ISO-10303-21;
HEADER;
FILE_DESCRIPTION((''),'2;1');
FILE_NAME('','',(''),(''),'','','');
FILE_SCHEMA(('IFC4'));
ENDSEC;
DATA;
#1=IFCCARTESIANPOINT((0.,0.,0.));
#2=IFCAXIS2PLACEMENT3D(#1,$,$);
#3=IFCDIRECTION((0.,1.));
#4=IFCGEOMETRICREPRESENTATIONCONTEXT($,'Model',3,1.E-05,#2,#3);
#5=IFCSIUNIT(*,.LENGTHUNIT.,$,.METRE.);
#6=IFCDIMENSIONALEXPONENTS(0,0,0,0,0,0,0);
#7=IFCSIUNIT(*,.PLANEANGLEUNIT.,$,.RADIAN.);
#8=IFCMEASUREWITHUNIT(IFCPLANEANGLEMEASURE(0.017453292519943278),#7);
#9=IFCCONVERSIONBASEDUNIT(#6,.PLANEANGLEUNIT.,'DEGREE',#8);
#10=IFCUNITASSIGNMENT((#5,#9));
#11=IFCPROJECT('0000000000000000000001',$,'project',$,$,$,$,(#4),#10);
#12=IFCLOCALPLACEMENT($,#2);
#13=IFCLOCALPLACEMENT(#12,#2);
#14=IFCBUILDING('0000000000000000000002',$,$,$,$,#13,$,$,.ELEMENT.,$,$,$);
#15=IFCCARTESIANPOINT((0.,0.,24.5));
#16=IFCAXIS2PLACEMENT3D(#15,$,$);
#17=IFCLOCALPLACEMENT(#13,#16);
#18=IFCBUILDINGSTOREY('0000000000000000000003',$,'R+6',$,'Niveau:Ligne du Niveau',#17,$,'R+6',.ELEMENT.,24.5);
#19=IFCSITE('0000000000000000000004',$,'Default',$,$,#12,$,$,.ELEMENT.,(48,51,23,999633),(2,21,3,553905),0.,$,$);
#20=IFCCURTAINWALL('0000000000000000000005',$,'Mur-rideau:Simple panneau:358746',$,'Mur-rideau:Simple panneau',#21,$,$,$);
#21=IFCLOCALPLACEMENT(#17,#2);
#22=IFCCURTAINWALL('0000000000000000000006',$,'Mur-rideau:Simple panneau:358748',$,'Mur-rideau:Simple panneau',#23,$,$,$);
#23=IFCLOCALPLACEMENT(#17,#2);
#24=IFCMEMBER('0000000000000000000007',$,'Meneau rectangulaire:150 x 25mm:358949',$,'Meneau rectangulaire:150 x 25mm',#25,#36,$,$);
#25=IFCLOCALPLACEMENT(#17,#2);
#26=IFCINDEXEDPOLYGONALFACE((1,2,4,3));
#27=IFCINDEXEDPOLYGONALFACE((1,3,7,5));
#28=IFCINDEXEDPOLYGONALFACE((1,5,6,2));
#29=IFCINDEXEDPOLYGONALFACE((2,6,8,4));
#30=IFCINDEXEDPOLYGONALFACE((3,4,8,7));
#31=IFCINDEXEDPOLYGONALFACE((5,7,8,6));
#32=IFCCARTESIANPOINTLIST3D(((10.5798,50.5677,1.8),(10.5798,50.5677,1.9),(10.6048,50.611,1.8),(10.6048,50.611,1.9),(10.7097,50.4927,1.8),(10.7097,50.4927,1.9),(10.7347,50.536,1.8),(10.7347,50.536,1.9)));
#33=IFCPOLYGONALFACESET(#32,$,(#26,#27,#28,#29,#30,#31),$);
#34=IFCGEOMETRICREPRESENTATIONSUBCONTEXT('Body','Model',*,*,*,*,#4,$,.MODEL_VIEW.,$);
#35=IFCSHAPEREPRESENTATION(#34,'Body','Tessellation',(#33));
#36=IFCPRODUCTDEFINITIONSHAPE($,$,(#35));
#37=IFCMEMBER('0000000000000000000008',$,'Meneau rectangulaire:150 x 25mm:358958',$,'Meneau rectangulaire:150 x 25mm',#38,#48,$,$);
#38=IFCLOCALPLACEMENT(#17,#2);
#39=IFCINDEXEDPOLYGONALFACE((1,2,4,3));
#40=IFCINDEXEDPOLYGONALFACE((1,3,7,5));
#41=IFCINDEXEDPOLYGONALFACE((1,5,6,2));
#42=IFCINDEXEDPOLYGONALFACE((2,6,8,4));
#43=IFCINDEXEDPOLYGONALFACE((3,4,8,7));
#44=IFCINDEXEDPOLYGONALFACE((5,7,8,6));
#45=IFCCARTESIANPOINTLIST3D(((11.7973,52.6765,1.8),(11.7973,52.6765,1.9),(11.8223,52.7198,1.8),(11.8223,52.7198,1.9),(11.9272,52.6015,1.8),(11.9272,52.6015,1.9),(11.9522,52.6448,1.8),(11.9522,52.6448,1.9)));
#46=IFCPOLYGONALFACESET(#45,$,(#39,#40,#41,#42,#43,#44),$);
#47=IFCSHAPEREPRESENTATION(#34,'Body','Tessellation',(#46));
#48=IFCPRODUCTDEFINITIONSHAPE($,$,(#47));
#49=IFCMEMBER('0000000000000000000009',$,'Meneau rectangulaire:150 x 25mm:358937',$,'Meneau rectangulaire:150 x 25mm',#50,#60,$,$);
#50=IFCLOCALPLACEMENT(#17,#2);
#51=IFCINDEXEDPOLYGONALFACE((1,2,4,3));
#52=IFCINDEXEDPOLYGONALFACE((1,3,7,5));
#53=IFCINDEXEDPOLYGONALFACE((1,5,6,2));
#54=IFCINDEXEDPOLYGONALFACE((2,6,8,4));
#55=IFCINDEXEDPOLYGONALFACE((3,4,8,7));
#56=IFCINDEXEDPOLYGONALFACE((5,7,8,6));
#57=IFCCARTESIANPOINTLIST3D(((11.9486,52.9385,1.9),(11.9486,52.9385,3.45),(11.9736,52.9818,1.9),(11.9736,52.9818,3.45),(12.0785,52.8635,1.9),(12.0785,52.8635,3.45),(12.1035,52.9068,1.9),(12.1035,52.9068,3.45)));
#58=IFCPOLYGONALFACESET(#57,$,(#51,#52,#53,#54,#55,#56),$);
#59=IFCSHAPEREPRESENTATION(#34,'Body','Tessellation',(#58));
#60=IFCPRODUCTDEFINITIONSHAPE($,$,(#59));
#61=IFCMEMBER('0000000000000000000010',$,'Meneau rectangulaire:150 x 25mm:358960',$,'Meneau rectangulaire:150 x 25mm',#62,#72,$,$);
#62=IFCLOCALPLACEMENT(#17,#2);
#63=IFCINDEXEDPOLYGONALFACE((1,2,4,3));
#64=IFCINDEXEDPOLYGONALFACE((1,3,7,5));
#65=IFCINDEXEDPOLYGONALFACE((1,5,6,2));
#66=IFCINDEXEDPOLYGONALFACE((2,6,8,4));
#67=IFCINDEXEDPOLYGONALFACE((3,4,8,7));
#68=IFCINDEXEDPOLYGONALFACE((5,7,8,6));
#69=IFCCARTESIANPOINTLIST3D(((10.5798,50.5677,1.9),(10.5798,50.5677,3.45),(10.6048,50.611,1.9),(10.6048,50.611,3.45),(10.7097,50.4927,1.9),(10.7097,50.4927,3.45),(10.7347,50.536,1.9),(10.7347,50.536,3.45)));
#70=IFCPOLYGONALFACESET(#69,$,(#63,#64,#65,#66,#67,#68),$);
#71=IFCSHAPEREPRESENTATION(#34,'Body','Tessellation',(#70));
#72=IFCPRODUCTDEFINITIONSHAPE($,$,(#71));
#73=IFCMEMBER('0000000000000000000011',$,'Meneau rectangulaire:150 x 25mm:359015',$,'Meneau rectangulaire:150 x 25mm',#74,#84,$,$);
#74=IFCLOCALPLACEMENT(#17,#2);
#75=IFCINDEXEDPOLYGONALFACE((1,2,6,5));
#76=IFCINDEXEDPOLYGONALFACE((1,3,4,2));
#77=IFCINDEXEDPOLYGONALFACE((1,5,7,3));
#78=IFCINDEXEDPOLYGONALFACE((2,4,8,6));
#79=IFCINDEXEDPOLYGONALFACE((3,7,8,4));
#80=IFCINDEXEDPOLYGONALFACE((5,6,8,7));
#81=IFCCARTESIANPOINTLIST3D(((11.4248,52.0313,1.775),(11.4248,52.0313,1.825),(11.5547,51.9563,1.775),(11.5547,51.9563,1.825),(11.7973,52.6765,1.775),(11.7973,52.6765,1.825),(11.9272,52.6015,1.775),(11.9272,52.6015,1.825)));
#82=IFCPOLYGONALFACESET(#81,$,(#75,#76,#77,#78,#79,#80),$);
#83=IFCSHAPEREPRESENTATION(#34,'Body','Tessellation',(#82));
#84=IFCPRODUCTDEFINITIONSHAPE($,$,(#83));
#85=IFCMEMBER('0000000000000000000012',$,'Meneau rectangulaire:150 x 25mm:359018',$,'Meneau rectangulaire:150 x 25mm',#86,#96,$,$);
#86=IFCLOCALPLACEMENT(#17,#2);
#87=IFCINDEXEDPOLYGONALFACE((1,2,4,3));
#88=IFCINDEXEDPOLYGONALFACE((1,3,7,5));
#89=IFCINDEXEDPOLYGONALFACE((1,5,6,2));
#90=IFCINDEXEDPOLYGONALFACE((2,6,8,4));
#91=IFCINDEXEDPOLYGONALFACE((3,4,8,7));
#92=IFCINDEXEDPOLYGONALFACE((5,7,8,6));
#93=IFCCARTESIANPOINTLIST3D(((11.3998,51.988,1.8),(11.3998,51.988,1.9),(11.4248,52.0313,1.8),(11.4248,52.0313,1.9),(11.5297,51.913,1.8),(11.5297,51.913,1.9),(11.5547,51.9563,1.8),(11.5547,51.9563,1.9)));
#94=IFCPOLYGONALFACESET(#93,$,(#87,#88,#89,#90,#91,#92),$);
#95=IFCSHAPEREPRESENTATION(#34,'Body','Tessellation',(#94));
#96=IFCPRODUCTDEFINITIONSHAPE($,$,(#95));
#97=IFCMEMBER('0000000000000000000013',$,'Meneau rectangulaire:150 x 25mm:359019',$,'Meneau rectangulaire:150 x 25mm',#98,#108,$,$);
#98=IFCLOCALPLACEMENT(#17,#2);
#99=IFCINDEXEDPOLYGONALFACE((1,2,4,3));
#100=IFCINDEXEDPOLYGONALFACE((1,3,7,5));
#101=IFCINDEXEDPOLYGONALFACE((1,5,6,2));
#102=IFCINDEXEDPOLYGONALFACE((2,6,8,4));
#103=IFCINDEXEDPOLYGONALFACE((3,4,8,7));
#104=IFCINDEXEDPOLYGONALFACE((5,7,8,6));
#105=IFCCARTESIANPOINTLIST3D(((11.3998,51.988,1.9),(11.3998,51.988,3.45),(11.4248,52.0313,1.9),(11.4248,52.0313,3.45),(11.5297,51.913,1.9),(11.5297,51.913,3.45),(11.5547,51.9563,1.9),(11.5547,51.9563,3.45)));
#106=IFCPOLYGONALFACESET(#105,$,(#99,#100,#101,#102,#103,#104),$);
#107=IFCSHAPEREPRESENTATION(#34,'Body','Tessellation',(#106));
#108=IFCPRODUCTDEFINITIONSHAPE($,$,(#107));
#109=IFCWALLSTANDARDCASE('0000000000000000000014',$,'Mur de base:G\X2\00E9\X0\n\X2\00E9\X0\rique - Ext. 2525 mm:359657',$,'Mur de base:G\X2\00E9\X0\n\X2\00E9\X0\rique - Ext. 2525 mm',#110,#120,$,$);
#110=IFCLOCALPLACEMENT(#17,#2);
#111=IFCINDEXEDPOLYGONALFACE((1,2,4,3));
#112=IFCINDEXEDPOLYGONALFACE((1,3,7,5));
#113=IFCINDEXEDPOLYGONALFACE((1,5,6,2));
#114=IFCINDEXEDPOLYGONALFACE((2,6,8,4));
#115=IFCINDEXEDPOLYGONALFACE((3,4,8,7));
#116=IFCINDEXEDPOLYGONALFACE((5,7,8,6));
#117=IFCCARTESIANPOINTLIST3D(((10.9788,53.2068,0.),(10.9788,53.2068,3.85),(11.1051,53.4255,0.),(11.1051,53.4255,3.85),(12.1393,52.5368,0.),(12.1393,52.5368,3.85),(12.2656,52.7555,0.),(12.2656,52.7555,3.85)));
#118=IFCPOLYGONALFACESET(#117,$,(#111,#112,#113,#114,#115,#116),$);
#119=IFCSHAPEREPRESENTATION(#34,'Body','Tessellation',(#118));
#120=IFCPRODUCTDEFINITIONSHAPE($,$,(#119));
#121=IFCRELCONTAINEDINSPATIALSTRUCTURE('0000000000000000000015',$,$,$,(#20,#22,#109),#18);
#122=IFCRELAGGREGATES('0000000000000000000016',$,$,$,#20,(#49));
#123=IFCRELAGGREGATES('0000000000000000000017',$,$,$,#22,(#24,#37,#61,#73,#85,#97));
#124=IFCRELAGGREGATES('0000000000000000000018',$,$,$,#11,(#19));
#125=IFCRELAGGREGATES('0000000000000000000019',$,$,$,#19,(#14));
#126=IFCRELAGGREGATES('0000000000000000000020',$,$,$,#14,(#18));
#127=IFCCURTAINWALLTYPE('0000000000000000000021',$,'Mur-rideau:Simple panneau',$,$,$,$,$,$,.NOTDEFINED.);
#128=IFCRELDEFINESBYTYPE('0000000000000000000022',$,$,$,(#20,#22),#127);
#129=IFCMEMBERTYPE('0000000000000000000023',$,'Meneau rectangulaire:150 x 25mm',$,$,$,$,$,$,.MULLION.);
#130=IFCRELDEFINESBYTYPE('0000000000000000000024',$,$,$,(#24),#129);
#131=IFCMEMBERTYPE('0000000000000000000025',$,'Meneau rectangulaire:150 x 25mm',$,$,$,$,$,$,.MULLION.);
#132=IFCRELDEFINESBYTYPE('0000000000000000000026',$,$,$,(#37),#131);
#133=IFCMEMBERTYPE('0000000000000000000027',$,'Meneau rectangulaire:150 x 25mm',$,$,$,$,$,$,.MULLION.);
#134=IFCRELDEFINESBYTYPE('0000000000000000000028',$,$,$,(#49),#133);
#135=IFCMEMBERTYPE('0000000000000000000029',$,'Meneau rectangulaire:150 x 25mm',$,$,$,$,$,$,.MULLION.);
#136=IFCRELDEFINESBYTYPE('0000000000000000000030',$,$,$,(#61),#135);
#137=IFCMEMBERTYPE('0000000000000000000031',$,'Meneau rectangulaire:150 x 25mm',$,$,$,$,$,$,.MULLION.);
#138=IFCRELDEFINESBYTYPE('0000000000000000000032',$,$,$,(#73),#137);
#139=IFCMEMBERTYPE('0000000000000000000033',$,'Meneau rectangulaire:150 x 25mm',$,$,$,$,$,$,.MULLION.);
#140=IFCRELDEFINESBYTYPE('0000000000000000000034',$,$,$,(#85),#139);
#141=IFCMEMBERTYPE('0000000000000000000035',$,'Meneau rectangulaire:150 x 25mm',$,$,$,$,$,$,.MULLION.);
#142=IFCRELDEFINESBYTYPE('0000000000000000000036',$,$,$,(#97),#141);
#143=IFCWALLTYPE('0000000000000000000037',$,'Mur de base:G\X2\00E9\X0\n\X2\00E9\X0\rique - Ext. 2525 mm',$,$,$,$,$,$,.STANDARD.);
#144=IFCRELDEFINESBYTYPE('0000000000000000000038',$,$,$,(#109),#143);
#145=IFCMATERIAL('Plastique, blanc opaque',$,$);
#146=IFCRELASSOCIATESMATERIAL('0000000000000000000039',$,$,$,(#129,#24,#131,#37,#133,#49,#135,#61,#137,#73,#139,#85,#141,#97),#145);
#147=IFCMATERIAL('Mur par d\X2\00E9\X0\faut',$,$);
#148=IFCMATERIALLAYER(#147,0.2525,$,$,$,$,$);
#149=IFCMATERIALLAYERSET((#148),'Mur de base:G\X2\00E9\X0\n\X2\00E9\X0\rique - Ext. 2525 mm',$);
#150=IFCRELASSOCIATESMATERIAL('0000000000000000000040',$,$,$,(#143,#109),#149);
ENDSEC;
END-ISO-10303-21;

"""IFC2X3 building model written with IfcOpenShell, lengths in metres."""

from ifc_helpers import new_model, entity, si_unit, converted_unit, direction, frame, frame_2d, origin, origin_2d_with_axis, place, context, subcontext, project, spatial, rectangle, extrude, source, transform, mapped, material, layer, layer_set, layer_usage, type_object, type_shapes, element, aggregate, save


model = new_model("IFC2X3")

# Units and contexts
model_context = context("Model", 3, precision=1e-05, world=origin(), true_north=direction((0.0, 1.0)))
body_context = subcontext(model_context, "Body", "Model", "MODEL_VIEW")
ifc_project = project(units=[si_unit("LENGTHUNIT", "METRE"), converted_unit("PLANEANGLEUNIT", "DEGREE", entity("IfcPlaneAngleMeasure", 0.017453292519943278), si_unit("PLANEANGLEUNIT", "RADIAN"), dimensions=[0, 0, 0, 0, 0, 0, 0])], contexts=[model_context])

# Site, building, storey
site_placement = place(None, origin())
site = spatial("IfcSite", under=ifc_project, at=site_placement, Name="Default", CompositionType="ELEMENT", RefLatitude=(48, 51, 23, 999633), RefLongitude=(2, 21, 3, 553905), RefElevation=0.0)
building_placement = place(site_placement, origin())
building = spatial("IfcBuilding", under=site, at=building_placement, CompositionType="ELEMENT")
storey_placement = place(building_placement, frame((0.0, 0.0, 24.5)))
storey = spatial("IfcBuildingStorey", under=building, at=storey_placement, Name="R+6", ObjectType="Niveau:Ligne du Niveau", LongName="R+6", CompositionType="ELEMENT", Elevation=24.5)

# Curtain wall
curtain_wall_type = type_object("IfcCurtainWallType", Name="Mur-rideau:Simple panneau", PredefinedType="NOTDEFINED")
curtain_wall_1_placement = place(storey_placement, frame((0.0, 0.0, -24.5)))
curtain_wall_1 = element("IfcCurtainWall", 1, at=curtain_wall_1_placement, inside=storey, type_object=curtain_wall_type, Name="Mur-rideau:Simple panneau:358746", ObjectType="Mur-rideau:Simple panneau")
ifc_material_1 = material(Name="Plastique, blanc opaque")

# Curtain wall
curtain_wall_2_placement = place(storey_placement, frame((0.0, 0.0, -24.5)))
curtain_wall_2 = element("IfcCurtainWall", 2, at=curtain_wall_2_placement, inside=storey, type_object=curtain_wall_type, Name="Mur-rideau:Simple panneau:358748", ObjectType="Mur-rideau:Simple panneau")

# Members
member_type_1 = type_object("IfcMemberType", Name="Meneau rectangulaire:150 x 25mm", PredefinedType="MULLION", material=ifc_material_1)
shared_shape_1 = source(origin(), body_context, "Body", "SweptSolid", [
    extrude(rectangle(XDim=0.05, YDim=0.15, at=origin_2d_with_axis()), frame((0.0, 0.0, -0.1), z_axis=(0.0, 0.0, 1.0), x_axis=(-1.0, 0.0, 0.0)), (0.0, 0.0, 1.0), 0.1),
])
type_shapes(member_type_1, [shared_shape_1])
member_1_placement = place(curtain_wall_2_placement, frame((10.6573, 50.5519, 26.3), z_axis=(0.0, 0.0, -1.0), x_axis=(-0.5, -0.866025, 0.0)))
member_1 = element("IfcMember", 3, at=member_1_placement, type_object=member_type_1, material=ifc_material_1, Name="Meneau rectangulaire:150 x 25mm:358949", ObjectType="Meneau rectangulaire:150 x 25mm", context=body_context, shape_type="MappedRepresentation", body=[
    mapped(shared_shape_1, transform((0.0, 0.0, 0.0), scale=1.0)),
])
member_type_2 = type_object("IfcMemberType", Name="Meneau rectangulaire:150 x 25mm", PredefinedType="MULLION", material=ifc_material_1)
shared_shape_2 = source(origin(), body_context, "Body", "SweptSolid", [
    extrude(rectangle(XDim=0.05, YDim=0.15, at=origin_2d_with_axis()), frame((-0.025, 0.0, -0.1), z_axis=(0.0, 0.0, 1.0), x_axis=(-1.0, 0.0, 0.0)), (0.0, 0.0, 1.0), 0.1),
])
type_shapes(member_type_2, [shared_shape_2])
member_2_placement = place(curtain_wall_2_placement, frame((11.8873, 52.6823, 26.4), z_axis=(0.0, 0.0, 1.0), x_axis=(0.5, 0.866025, 0.0)))
member_2 = element("IfcMember", 4, at=member_2_placement, type_object=member_type_2, material=ifc_material_1, Name="Meneau rectangulaire:150 x 25mm:358958", ObjectType="Meneau rectangulaire:150 x 25mm", context=body_context, shape_type="MappedRepresentation", body=[
    mapped(shared_shape_2, transform((0.0, 0.0, 0.0), scale=1.0)),
])
member_type_3 = type_object("IfcMemberType", Name="Meneau rectangulaire:150 x 25mm", PredefinedType="MULLION", material=ifc_material_1)
shared_shape_3 = source(origin(), body_context, "Body", "SweptSolid", [
    extrude(rectangle(XDim=0.05, YDim=0.15, at=origin_2d_with_axis()), frame((-0.025, 0.0, -1.55), z_axis=(0.0, 0.0, 1.0), x_axis=(-1.0, 0.0, 0.0)), (0.0, 0.0, 1.0), 1.55),
])
type_shapes(member_type_3, [shared_shape_3])
member_3_placement = place(curtain_wall_1_placement, frame((12.0135, 52.901, 26.4), z_axis=(0.0, 0.0, -1.0), x_axis=(-0.5, -0.866025, 0.0)))
member_3 = element("IfcMember", 5, at=member_3_placement, type_object=member_type_3, material=ifc_material_1, Name="Meneau rectangulaire:150 x 25mm:358937", ObjectType="Meneau rectangulaire:150 x 25mm", context=body_context, shape_type="MappedRepresentation", body=[
    mapped(shared_shape_3, transform((0.0, 0.0, 0.0), scale=1.0)),
])
member_type_4 = type_object("IfcMemberType", Name="Meneau rectangulaire:150 x 25mm", PredefinedType="MULLION", material=ifc_material_1)
shared_shape_4 = source(origin(), body_context, "Body", "SweptSolid", [
    extrude(rectangle(XDim=0.05, YDim=0.15, at=origin_2d_with_axis()), frame((0.0, 0.0, -1.55), z_axis=(0.0, 0.0, 1.0), x_axis=(-1.0, 0.0, 0.0)), (0.0, 0.0, 1.0), 1.55),
])
type_shapes(member_type_4, [shared_shape_4])
member_4_placement = place(curtain_wall_2_placement, frame((10.6573, 50.5519, 26.4), z_axis=(0.0, 0.0, -1.0), x_axis=(-0.5, -0.866025, 0.0)))
member_4 = element("IfcMember", 6, at=member_4_placement, type_object=member_type_4, material=ifc_material_1, Name="Meneau rectangulaire:150 x 25mm:358960", ObjectType="Meneau rectangulaire:150 x 25mm", context=body_context, shape_type="MappedRepresentation", body=[
    mapped(shared_shape_4, transform((0.0, 0.0, 0.0), scale=1.0)),
])
member_type_5 = type_object("IfcMemberType", Name="Meneau rectangulaire:150 x 25mm", PredefinedType="MULLION", material=ifc_material_1)
shared_shape_5 = source(origin(), body_context, "Body", "SweptSolid", [
    extrude(rectangle(XDim=0.05, YDim=0.15, at=origin_2d_with_axis()), frame((0.0, 0.0, -0.745), z_axis=(0.0, 0.0, 1.0), x_axis=(-1.0, 0.0, 0.0)), (0.0, 0.0, 1.0), 0.745),
])
type_shapes(member_type_5, [shared_shape_5])
member_5_placement = place(curtain_wall_2_placement, frame((11.4898, 51.9938, 26.3), z_axis=(-0.5, -0.866025, 0.0), x_axis=(0.0, 0.0, 1.0)))
member_5 = element("IfcMember", 7, at=member_5_placement, type_object=member_type_5, material=ifc_material_1, Name="Meneau rectangulaire:150 x 25mm:359015", ObjectType="Meneau rectangulaire:150 x 25mm", context=body_context, shape_type="MappedRepresentation", body=[
    mapped(shared_shape_5, transform((0.0, 0.0, 0.0), scale=1.0)),
])
member_type_6 = type_object("IfcMemberType", Name="Meneau rectangulaire:150 x 25mm", PredefinedType="MULLION", material=ifc_material_1)
shared_shape_6 = source(origin(), body_context, "Body", "SweptSolid", [
    extrude(rectangle(XDim=0.05, YDim=0.15, at=origin_2d_with_axis()), frame((0.0, 0.0, -0.1), z_axis=(0.0, 0.0, 1.0), x_axis=(-1.0, 0.0, 0.0)), (0.0, 0.0, 1.0), 0.1),
])
type_shapes(member_type_6, [shared_shape_6])
member_6_placement = place(curtain_wall_2_placement, frame((11.4773, 51.9722, 26.3), z_axis=(0.0, 0.0, -1.0), x_axis=(-0.5, -0.866025, 0.0)))
member_6 = element("IfcMember", 8, at=member_6_placement, type_object=member_type_6, material=ifc_material_1, Name="Meneau rectangulaire:150 x 25mm:359018", ObjectType="Meneau rectangulaire:150 x 25mm", context=body_context, shape_type="MappedRepresentation", body=[
    mapped(shared_shape_6, transform((0.0, 0.0, 0.0), scale=1.0)),
])
member_type_7 = type_object("IfcMemberType", Name="Meneau rectangulaire:150 x 25mm", PredefinedType="MULLION", material=ifc_material_1)
shared_shape_7 = source(origin(), body_context, "Body", "SweptSolid", [
    extrude(rectangle(XDim=0.05, YDim=0.15, at=origin_2d_with_axis()), frame((0.0, 0.0, -1.55), z_axis=(0.0, 0.0, 1.0), x_axis=(-1.0, 0.0, 0.0)), (0.0, 0.0, 1.0), 1.55),
])
type_shapes(member_type_7, [shared_shape_7])
member_7_placement = place(curtain_wall_2_placement, frame((11.4773, 51.9722, 26.4), z_axis=(0.0, 0.0, -1.0), x_axis=(-0.5, -0.866025, 0.0)))
member_7 = element("IfcMember", 9, at=member_7_placement, type_object=member_type_7, material=ifc_material_1, Name="Meneau rectangulaire:150 x 25mm:359019", ObjectType="Meneau rectangulaire:150 x 25mm", context=body_context, shape_type="MappedRepresentation", body=[
    mapped(shared_shape_7, transform((0.0, 0.0, 0.0), scale=1.0)),
])

aggregate(curtain_wall_1, [member_3])
aggregate(curtain_wall_2, [member_1, member_2, member_4, member_5, member_6, member_7])

# Wall
ifc_material_2 = material(Name="Mur par défaut")
ifc_layer_1 = layer(ifc_material_2, 0.2525)
ifc_layer_set_1 = layer_set([ifc_layer_1], Name="Mur de base:Générique - Ext. 2525 mm")
ifc_layer_usage = layer_usage(ifc_layer_set_1, "AXIS2", "NEGATIVE", 0.1263)
wall_type = type_object("IfcWallType", Name="Mur de base:Générique - Ext. 2525 mm", PredefinedType="STANDARD", material=ifc_layer_set_1)
wall_placement = place(storey_placement, frame((12.2024, 52.6461, 0.0), z_axis=(0.0, 0.0, 1.0), x_axis=(-0.866025, 0.5, 0.0)))
element("IfcWallStandardCase", 10, at=wall_placement, inside=storey, type_object=wall_type, material=ifc_layer_usage, Name="Mur de base:Générique - Ext. 2525 mm:359657", ObjectType="Mur de base:Générique - Ext. 2525 mm", context=body_context, shape_type="SweptSolid", body=[
    extrude(rectangle(XDim=1.34, YDim=0.2525, at=frame_2d((0.67, 0.0), x_axis=(-1.0, 0.0))), origin(), (0.0, 0.0, 1.0), 3.85),
])

save(model, "model.ifc")
